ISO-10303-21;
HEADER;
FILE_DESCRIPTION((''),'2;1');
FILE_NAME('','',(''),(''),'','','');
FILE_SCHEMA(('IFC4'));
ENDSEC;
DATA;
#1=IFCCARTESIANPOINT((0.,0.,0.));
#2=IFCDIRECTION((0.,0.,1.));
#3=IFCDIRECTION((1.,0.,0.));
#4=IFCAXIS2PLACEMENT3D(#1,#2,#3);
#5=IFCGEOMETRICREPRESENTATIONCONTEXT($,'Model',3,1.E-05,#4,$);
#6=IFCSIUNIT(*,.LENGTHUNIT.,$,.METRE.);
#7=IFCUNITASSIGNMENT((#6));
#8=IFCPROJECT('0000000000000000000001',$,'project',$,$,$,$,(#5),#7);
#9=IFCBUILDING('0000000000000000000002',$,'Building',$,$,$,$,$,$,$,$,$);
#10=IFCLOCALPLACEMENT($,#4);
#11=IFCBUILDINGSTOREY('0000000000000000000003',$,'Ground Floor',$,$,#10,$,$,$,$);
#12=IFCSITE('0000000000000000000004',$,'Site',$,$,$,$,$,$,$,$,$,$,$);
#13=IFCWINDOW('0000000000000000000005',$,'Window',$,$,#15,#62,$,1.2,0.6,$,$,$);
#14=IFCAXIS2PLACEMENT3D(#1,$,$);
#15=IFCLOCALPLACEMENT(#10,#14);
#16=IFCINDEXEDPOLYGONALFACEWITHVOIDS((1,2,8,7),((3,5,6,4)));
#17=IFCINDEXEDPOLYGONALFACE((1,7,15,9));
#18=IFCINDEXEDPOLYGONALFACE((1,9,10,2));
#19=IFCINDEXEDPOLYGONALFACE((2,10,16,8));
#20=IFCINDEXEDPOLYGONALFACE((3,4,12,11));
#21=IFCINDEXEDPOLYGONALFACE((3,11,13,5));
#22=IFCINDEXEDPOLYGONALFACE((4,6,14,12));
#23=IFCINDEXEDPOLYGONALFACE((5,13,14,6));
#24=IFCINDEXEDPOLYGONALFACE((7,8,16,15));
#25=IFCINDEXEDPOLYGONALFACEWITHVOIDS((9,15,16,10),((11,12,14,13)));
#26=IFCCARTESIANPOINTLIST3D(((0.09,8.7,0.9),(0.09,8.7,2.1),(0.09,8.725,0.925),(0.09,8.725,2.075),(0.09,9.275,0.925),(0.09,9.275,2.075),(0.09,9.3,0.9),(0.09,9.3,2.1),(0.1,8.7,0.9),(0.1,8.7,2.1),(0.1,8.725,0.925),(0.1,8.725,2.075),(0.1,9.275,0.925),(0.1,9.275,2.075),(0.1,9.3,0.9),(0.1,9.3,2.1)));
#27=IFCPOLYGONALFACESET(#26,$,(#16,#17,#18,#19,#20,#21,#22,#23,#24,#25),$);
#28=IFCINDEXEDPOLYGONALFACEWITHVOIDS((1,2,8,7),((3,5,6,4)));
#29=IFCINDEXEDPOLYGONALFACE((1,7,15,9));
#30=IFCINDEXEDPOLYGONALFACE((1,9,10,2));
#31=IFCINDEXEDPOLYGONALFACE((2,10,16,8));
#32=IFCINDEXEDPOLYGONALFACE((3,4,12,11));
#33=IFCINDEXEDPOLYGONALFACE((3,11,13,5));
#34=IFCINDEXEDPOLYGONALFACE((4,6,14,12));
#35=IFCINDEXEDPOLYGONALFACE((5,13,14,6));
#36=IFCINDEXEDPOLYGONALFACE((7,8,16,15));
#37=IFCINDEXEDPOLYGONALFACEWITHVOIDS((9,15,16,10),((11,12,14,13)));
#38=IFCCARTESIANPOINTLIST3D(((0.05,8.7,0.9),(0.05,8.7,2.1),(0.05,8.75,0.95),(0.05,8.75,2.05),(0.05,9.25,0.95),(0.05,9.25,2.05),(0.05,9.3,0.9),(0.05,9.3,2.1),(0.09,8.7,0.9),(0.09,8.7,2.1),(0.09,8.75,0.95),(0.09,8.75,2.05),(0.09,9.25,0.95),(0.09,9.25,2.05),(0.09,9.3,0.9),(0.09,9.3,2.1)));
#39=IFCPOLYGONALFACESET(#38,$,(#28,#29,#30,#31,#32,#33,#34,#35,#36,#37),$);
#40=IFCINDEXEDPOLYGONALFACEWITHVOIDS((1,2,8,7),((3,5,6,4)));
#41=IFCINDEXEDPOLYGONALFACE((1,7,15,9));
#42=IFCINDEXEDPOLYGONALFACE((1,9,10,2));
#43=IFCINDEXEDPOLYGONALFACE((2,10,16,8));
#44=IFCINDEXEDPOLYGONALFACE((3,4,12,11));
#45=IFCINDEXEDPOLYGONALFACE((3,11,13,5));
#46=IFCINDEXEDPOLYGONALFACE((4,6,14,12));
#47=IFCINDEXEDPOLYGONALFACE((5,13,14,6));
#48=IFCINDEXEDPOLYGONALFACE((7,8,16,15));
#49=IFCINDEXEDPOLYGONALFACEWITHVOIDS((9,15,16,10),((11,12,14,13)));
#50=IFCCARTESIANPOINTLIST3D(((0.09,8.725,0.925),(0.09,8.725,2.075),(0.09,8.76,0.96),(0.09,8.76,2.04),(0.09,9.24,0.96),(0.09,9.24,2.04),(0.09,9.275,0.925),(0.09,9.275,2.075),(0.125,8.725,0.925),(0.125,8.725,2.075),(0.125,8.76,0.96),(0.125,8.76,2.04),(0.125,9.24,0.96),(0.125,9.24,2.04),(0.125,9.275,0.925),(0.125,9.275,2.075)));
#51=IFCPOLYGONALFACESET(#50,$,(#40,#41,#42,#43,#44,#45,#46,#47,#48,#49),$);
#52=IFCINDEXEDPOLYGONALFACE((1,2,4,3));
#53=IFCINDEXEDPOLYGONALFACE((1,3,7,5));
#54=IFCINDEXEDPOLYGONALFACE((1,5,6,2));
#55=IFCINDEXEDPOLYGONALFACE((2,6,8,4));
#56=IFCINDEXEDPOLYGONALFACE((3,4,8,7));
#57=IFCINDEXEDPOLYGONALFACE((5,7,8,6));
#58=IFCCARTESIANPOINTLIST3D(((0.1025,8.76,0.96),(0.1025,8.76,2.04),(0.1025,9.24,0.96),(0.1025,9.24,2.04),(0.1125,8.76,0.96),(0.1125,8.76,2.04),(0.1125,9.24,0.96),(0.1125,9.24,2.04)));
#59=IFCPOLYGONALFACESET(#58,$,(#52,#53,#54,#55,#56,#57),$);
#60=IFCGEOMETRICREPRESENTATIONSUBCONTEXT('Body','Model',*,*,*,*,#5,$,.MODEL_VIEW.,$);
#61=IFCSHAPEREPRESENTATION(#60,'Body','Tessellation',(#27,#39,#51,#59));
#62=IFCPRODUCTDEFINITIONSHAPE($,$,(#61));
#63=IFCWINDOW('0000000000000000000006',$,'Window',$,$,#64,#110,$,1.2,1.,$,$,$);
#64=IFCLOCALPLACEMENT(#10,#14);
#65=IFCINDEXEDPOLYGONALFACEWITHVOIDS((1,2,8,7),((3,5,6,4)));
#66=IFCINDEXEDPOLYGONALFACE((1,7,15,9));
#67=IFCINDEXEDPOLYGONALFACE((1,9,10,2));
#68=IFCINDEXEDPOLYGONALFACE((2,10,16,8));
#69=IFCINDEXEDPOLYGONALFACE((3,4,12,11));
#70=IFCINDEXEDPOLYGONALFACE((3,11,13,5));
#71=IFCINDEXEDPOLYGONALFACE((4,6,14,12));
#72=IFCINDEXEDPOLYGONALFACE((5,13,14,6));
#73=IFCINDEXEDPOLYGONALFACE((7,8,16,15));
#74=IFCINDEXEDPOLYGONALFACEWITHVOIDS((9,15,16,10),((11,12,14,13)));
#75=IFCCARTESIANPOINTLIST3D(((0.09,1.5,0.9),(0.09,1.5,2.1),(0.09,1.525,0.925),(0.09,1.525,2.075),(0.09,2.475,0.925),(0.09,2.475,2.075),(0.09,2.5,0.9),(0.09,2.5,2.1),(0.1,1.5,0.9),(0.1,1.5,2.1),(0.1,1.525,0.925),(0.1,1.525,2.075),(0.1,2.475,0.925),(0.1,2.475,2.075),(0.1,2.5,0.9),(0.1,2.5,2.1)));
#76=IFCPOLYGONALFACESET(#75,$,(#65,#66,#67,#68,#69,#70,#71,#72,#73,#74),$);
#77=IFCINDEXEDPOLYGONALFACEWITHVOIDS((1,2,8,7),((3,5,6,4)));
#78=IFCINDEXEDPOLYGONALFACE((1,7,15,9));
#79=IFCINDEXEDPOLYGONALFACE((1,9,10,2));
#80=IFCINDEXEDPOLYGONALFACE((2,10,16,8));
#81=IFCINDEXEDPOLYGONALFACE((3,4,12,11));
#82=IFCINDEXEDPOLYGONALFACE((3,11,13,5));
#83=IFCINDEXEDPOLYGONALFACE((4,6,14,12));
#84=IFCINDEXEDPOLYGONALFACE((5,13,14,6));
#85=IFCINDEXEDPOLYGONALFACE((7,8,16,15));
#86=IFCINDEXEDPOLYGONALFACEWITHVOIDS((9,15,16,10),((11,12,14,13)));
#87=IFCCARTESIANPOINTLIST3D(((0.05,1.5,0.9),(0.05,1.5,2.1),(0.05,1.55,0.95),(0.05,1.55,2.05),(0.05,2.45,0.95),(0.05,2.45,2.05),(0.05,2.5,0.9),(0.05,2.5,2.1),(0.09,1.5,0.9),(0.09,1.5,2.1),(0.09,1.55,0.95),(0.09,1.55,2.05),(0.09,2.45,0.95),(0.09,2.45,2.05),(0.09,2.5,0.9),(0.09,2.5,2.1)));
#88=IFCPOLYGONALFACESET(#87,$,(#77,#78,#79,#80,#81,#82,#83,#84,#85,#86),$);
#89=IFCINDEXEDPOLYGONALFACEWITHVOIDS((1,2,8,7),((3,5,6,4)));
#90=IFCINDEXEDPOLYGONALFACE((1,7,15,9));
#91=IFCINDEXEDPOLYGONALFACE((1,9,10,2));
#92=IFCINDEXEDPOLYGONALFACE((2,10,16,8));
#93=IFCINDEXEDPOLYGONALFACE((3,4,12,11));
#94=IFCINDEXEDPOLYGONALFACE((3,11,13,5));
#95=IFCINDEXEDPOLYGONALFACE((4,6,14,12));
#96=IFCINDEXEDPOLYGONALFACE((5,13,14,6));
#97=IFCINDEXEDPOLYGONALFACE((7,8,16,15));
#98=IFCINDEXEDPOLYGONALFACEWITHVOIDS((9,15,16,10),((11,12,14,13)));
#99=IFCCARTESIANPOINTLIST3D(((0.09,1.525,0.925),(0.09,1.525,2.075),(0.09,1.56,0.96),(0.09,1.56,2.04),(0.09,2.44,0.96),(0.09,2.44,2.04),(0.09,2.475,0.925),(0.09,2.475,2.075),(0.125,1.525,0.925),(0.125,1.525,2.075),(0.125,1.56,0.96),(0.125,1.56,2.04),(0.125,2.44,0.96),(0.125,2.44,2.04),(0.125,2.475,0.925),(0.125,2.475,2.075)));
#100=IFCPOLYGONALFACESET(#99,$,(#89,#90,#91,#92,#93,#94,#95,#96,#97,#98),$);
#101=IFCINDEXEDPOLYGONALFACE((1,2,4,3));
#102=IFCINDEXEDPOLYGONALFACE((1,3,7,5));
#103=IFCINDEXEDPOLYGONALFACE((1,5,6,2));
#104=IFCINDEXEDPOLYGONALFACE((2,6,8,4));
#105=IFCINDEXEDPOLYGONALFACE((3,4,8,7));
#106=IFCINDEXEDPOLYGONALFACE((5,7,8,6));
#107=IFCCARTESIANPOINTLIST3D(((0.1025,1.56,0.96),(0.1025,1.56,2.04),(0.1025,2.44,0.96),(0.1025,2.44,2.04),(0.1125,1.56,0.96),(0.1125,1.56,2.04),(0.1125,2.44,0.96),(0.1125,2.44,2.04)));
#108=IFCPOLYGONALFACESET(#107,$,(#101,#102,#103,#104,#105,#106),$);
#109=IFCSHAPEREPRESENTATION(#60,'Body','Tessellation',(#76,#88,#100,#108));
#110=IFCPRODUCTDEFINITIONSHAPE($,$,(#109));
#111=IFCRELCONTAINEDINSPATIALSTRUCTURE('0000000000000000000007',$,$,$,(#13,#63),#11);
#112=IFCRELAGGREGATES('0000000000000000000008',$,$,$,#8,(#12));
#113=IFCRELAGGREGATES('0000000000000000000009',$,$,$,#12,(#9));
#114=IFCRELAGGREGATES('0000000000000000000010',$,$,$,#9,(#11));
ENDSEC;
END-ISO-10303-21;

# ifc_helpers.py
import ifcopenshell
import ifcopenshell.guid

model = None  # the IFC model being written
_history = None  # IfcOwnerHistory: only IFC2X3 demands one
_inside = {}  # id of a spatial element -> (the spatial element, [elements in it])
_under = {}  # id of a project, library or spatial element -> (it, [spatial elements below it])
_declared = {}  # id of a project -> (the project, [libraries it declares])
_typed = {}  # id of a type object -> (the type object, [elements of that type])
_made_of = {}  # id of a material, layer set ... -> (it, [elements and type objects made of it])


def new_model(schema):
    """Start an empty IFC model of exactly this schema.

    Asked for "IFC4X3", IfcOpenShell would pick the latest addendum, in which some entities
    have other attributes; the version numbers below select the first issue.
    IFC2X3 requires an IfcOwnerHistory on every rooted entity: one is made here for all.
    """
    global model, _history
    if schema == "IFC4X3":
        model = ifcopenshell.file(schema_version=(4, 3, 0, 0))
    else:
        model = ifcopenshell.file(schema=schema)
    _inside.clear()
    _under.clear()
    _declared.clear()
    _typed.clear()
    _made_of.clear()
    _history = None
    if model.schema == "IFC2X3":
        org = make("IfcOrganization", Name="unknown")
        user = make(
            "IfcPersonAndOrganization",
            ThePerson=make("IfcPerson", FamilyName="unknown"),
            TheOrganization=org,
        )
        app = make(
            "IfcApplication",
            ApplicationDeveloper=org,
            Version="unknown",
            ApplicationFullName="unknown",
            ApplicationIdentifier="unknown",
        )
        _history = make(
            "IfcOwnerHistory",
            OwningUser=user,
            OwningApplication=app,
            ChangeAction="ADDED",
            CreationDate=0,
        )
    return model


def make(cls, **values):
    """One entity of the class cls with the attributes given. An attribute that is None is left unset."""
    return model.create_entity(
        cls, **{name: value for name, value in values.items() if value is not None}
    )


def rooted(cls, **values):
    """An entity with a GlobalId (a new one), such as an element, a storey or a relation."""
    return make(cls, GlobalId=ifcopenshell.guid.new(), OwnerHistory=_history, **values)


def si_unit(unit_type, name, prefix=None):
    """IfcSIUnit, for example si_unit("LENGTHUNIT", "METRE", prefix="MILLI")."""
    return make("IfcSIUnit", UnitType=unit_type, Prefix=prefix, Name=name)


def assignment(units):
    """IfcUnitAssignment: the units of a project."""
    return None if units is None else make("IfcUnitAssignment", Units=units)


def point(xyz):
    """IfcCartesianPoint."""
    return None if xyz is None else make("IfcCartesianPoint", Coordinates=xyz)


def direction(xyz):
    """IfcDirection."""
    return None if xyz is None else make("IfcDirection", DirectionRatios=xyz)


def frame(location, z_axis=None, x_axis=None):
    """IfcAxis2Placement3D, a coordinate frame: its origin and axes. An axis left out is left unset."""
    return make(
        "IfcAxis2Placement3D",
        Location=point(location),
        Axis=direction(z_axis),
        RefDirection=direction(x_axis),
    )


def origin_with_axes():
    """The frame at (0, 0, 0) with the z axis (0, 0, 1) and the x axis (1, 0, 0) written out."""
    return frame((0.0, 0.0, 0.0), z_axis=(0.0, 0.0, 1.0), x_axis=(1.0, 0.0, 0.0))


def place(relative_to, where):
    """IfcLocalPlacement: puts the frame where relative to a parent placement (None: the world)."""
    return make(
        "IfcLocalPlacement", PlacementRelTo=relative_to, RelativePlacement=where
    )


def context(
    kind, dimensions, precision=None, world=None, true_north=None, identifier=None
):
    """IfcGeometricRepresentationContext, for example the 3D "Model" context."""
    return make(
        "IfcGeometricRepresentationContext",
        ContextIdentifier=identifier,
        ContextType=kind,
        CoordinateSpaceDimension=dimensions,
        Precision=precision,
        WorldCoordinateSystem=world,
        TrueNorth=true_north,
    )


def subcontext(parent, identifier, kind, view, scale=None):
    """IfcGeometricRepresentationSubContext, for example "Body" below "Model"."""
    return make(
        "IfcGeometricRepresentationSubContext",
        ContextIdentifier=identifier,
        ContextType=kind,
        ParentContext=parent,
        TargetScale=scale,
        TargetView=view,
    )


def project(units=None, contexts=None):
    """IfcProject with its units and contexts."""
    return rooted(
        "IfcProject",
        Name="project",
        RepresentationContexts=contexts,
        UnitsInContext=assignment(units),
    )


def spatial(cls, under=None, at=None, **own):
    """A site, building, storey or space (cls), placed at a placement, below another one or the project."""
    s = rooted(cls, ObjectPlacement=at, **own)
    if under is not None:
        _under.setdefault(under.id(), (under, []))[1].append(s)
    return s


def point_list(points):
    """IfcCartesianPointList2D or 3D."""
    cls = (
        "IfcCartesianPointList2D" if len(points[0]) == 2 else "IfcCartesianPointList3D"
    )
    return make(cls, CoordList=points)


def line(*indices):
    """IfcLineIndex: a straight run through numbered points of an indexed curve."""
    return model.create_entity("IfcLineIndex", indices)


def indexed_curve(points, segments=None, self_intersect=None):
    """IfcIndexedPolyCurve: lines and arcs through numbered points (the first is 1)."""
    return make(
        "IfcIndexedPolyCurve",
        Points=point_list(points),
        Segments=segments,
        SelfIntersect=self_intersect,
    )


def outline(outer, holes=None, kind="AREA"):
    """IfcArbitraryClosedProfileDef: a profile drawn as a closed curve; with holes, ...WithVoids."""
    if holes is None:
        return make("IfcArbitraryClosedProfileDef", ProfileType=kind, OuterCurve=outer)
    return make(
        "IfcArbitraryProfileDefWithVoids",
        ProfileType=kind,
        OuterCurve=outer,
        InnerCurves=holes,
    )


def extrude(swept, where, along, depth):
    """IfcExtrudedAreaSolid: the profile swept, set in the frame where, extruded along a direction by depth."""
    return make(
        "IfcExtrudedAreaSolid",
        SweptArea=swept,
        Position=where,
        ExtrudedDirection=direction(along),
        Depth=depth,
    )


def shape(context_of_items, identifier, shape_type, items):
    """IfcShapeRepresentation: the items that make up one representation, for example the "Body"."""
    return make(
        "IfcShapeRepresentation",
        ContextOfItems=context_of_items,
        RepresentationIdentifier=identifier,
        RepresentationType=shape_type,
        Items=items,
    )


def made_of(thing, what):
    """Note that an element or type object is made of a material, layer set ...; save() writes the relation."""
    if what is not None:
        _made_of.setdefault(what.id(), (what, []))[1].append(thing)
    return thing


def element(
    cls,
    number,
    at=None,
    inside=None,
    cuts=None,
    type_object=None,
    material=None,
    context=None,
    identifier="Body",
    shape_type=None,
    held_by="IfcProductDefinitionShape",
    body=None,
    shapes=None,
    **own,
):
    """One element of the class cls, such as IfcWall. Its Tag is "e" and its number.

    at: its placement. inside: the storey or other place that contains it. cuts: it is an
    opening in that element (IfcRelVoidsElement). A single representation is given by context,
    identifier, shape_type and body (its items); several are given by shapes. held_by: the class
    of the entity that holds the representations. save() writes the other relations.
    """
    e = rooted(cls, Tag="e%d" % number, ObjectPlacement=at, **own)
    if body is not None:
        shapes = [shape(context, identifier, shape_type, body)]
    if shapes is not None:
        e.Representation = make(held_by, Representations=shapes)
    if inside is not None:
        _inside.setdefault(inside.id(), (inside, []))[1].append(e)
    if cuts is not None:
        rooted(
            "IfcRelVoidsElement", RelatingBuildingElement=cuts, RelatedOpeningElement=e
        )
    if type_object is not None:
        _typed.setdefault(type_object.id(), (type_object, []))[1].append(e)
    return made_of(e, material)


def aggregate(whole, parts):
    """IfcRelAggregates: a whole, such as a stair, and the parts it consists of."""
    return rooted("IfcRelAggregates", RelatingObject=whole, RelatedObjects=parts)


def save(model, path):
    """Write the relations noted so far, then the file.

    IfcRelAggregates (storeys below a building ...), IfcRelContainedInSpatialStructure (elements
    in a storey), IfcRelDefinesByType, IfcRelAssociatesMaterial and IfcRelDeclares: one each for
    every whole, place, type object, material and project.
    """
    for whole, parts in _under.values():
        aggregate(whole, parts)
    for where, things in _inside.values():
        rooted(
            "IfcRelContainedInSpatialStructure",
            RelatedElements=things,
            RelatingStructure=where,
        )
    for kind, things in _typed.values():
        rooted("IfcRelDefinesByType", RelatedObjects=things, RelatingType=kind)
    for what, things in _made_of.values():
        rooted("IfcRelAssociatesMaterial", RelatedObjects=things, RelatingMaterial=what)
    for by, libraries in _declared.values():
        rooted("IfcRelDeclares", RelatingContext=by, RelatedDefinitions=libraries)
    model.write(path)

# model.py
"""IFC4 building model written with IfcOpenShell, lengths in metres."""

from ifc_helpers import new_model, si_unit, frame, origin_with_axes, place, context, subcontext, project, spatial, line, indexed_curve, outline, extrude, element, save


model = new_model("IFC4")

# Units and contexts
model_context = context("Model", 3, precision=1e-05, world=origin_with_axes())
body_context = subcontext(model_context, "Body", "Model", "MODEL_VIEW")
ifc_project = project(units=[si_unit("LENGTHUNIT", "METRE")], contexts=[model_context])

# Site, building, storey
site = spatial("IfcSite", under=ifc_project, Name="Site")
building = spatial("IfcBuilding", under=site, Name="Building")
storey_placement = place(None, origin_with_axes())
storey = spatial("IfcBuildingStorey", under=building, at=storey_placement, Name="Ground Floor")

# Windows
window_1_placement = place(storey_placement, frame((0.0, 9.3, 0.9), z_axis=(0.0, 0.0, 1.0), x_axis=(0.0, -1.0, 0.0)))
element("IfcWindow", 1, at=window_1_placement, inside=storey, Name="Window", OverallHeight=1.2, OverallWidth=0.6, context=body_context, shape_type="SweptSolid", body=[
    extrude(outline(indexed_curve([(0.0, 0.0), (0.6, 0.0), (0.6, 1.2), (0.0, 1.2)], segments=[line(1, 2, 3, 4, 1)]), holes=[indexed_curve([(0.025, 0.025), (0.575, 0.025), (0.575, 1.175), (0.025, 1.175)], segments=[line(1, 2, 3, 4, 1)])]), frame((0.0, 0.09, 0.0), z_axis=(0.0, -1.0, 0.0), x_axis=(1.0, 0.0, 0.0)), (0.0, 0.0, -1.0), 0.01),
    extrude(outline(indexed_curve([(0.0, 0.0), (0.6, 0.0), (0.6, 1.2), (0.0, 1.2)], segments=[line(1, 2, 3, 4, 1)]), holes=[indexed_curve([(0.05, 0.05), (0.55, 0.05), (0.55, 1.15), (0.05, 1.15)], segments=[line(1, 2, 3, 4, 1)])]), frame((0.0, 0.05, 0.0), z_axis=(0.0, -1.0, 0.0), x_axis=(1.0, 0.0, 0.0)), (0.0, 0.0, -1.0), 0.04),
    extrude(outline(indexed_curve([(0.0, 0.0), (0.55, 0.0), (0.55, 1.15), (0.0, 1.15)], segments=[line(1, 2, 3, 4, 1)]), holes=[indexed_curve([(0.035, 0.035), (0.515, 0.035), (0.515, 1.115), (0.035, 1.115)], segments=[line(1, 2, 3, 4, 1)])]), frame((0.025, 0.09, 0.025), z_axis=(0.0, -1.0, 0.0), x_axis=(1.0, 0.0, 0.0)), (0.0, 0.0, -1.0), 0.035),
    extrude(outline(indexed_curve([(0.035, 0.035), (0.515, 0.035), (0.515, 1.115), (0.035, 1.115)], segments=[line(1, 2, 3, 4, 1)])), frame((0.025, 0.1025, 0.025), z_axis=(0.0, -1.0, 0.0), x_axis=(1.0, 0.0, 0.0)), (0.0, 0.0, -1.0), 0.01),
])
window_2_placement = place(storey_placement, frame((0.0, 2.5, 0.9), z_axis=(0.0, 0.0, 1.0), x_axis=(0.0, -1.0, 0.0)))
element("IfcWindow", 2, at=window_2_placement, inside=storey, Name="Window", OverallHeight=1.2, OverallWidth=1.0, context=body_context, shape_type="SweptSolid", body=[
    extrude(outline(indexed_curve([(0.0, 0.0), (1.0, 0.0), (1.0, 1.2), (0.0, 1.2)], segments=[line(1, 2, 3, 4, 1)]), holes=[indexed_curve([(0.025, 0.025), (0.975, 0.025), (0.975, 1.175), (0.025, 1.175)], segments=[line(1, 2, 3, 4, 1)])]), frame((0.0, 0.09, 0.0), z_axis=(0.0, -1.0, 0.0), x_axis=(1.0, 0.0, 0.0)), (0.0, 0.0, -1.0), 0.01),
    extrude(outline(indexed_curve([(0.0, 0.0), (1.0, 0.0), (1.0, 1.2), (0.0, 1.2)], segments=[line(1, 2, 3, 4, 1)]), holes=[indexed_curve([(0.05, 0.05), (0.95, 0.05), (0.95, 1.15), (0.05, 1.15)], segments=[line(1, 2, 3, 4, 1)])]), frame((0.0, 0.05, 0.0), z_axis=(0.0, -1.0, 0.0), x_axis=(1.0, 0.0, 0.0)), (0.0, 0.0, -1.0), 0.04),
    extrude(outline(indexed_curve([(0.0, 0.0), (0.95, 0.0), (0.95, 1.15), (0.0, 1.15)], segments=[line(1, 2, 3, 4, 1)]), holes=[indexed_curve([(0.035, 0.035), (0.915, 0.035), (0.915, 1.115), (0.035, 1.115)], segments=[line(1, 2, 3, 4, 1)])]), frame((0.025, 0.09, 0.025), z_axis=(0.0, -1.0, 0.0), x_axis=(1.0, 0.0, 0.0)), (0.0, 0.0, -1.0), 0.035),
    extrude(outline(indexed_curve([(0.035, 0.035), (0.915, 0.035), (0.915, 1.115), (0.035, 1.115)], segments=[line(1, 2, 3, 4, 1)])), frame((0.025, 0.1025, 0.025), z_axis=(0.0, -1.0, 0.0), x_axis=(1.0, 0.0, 0.0)), (0.0, 0.0, -1.0), 0.01),
])

save(model, "model.ifc")
